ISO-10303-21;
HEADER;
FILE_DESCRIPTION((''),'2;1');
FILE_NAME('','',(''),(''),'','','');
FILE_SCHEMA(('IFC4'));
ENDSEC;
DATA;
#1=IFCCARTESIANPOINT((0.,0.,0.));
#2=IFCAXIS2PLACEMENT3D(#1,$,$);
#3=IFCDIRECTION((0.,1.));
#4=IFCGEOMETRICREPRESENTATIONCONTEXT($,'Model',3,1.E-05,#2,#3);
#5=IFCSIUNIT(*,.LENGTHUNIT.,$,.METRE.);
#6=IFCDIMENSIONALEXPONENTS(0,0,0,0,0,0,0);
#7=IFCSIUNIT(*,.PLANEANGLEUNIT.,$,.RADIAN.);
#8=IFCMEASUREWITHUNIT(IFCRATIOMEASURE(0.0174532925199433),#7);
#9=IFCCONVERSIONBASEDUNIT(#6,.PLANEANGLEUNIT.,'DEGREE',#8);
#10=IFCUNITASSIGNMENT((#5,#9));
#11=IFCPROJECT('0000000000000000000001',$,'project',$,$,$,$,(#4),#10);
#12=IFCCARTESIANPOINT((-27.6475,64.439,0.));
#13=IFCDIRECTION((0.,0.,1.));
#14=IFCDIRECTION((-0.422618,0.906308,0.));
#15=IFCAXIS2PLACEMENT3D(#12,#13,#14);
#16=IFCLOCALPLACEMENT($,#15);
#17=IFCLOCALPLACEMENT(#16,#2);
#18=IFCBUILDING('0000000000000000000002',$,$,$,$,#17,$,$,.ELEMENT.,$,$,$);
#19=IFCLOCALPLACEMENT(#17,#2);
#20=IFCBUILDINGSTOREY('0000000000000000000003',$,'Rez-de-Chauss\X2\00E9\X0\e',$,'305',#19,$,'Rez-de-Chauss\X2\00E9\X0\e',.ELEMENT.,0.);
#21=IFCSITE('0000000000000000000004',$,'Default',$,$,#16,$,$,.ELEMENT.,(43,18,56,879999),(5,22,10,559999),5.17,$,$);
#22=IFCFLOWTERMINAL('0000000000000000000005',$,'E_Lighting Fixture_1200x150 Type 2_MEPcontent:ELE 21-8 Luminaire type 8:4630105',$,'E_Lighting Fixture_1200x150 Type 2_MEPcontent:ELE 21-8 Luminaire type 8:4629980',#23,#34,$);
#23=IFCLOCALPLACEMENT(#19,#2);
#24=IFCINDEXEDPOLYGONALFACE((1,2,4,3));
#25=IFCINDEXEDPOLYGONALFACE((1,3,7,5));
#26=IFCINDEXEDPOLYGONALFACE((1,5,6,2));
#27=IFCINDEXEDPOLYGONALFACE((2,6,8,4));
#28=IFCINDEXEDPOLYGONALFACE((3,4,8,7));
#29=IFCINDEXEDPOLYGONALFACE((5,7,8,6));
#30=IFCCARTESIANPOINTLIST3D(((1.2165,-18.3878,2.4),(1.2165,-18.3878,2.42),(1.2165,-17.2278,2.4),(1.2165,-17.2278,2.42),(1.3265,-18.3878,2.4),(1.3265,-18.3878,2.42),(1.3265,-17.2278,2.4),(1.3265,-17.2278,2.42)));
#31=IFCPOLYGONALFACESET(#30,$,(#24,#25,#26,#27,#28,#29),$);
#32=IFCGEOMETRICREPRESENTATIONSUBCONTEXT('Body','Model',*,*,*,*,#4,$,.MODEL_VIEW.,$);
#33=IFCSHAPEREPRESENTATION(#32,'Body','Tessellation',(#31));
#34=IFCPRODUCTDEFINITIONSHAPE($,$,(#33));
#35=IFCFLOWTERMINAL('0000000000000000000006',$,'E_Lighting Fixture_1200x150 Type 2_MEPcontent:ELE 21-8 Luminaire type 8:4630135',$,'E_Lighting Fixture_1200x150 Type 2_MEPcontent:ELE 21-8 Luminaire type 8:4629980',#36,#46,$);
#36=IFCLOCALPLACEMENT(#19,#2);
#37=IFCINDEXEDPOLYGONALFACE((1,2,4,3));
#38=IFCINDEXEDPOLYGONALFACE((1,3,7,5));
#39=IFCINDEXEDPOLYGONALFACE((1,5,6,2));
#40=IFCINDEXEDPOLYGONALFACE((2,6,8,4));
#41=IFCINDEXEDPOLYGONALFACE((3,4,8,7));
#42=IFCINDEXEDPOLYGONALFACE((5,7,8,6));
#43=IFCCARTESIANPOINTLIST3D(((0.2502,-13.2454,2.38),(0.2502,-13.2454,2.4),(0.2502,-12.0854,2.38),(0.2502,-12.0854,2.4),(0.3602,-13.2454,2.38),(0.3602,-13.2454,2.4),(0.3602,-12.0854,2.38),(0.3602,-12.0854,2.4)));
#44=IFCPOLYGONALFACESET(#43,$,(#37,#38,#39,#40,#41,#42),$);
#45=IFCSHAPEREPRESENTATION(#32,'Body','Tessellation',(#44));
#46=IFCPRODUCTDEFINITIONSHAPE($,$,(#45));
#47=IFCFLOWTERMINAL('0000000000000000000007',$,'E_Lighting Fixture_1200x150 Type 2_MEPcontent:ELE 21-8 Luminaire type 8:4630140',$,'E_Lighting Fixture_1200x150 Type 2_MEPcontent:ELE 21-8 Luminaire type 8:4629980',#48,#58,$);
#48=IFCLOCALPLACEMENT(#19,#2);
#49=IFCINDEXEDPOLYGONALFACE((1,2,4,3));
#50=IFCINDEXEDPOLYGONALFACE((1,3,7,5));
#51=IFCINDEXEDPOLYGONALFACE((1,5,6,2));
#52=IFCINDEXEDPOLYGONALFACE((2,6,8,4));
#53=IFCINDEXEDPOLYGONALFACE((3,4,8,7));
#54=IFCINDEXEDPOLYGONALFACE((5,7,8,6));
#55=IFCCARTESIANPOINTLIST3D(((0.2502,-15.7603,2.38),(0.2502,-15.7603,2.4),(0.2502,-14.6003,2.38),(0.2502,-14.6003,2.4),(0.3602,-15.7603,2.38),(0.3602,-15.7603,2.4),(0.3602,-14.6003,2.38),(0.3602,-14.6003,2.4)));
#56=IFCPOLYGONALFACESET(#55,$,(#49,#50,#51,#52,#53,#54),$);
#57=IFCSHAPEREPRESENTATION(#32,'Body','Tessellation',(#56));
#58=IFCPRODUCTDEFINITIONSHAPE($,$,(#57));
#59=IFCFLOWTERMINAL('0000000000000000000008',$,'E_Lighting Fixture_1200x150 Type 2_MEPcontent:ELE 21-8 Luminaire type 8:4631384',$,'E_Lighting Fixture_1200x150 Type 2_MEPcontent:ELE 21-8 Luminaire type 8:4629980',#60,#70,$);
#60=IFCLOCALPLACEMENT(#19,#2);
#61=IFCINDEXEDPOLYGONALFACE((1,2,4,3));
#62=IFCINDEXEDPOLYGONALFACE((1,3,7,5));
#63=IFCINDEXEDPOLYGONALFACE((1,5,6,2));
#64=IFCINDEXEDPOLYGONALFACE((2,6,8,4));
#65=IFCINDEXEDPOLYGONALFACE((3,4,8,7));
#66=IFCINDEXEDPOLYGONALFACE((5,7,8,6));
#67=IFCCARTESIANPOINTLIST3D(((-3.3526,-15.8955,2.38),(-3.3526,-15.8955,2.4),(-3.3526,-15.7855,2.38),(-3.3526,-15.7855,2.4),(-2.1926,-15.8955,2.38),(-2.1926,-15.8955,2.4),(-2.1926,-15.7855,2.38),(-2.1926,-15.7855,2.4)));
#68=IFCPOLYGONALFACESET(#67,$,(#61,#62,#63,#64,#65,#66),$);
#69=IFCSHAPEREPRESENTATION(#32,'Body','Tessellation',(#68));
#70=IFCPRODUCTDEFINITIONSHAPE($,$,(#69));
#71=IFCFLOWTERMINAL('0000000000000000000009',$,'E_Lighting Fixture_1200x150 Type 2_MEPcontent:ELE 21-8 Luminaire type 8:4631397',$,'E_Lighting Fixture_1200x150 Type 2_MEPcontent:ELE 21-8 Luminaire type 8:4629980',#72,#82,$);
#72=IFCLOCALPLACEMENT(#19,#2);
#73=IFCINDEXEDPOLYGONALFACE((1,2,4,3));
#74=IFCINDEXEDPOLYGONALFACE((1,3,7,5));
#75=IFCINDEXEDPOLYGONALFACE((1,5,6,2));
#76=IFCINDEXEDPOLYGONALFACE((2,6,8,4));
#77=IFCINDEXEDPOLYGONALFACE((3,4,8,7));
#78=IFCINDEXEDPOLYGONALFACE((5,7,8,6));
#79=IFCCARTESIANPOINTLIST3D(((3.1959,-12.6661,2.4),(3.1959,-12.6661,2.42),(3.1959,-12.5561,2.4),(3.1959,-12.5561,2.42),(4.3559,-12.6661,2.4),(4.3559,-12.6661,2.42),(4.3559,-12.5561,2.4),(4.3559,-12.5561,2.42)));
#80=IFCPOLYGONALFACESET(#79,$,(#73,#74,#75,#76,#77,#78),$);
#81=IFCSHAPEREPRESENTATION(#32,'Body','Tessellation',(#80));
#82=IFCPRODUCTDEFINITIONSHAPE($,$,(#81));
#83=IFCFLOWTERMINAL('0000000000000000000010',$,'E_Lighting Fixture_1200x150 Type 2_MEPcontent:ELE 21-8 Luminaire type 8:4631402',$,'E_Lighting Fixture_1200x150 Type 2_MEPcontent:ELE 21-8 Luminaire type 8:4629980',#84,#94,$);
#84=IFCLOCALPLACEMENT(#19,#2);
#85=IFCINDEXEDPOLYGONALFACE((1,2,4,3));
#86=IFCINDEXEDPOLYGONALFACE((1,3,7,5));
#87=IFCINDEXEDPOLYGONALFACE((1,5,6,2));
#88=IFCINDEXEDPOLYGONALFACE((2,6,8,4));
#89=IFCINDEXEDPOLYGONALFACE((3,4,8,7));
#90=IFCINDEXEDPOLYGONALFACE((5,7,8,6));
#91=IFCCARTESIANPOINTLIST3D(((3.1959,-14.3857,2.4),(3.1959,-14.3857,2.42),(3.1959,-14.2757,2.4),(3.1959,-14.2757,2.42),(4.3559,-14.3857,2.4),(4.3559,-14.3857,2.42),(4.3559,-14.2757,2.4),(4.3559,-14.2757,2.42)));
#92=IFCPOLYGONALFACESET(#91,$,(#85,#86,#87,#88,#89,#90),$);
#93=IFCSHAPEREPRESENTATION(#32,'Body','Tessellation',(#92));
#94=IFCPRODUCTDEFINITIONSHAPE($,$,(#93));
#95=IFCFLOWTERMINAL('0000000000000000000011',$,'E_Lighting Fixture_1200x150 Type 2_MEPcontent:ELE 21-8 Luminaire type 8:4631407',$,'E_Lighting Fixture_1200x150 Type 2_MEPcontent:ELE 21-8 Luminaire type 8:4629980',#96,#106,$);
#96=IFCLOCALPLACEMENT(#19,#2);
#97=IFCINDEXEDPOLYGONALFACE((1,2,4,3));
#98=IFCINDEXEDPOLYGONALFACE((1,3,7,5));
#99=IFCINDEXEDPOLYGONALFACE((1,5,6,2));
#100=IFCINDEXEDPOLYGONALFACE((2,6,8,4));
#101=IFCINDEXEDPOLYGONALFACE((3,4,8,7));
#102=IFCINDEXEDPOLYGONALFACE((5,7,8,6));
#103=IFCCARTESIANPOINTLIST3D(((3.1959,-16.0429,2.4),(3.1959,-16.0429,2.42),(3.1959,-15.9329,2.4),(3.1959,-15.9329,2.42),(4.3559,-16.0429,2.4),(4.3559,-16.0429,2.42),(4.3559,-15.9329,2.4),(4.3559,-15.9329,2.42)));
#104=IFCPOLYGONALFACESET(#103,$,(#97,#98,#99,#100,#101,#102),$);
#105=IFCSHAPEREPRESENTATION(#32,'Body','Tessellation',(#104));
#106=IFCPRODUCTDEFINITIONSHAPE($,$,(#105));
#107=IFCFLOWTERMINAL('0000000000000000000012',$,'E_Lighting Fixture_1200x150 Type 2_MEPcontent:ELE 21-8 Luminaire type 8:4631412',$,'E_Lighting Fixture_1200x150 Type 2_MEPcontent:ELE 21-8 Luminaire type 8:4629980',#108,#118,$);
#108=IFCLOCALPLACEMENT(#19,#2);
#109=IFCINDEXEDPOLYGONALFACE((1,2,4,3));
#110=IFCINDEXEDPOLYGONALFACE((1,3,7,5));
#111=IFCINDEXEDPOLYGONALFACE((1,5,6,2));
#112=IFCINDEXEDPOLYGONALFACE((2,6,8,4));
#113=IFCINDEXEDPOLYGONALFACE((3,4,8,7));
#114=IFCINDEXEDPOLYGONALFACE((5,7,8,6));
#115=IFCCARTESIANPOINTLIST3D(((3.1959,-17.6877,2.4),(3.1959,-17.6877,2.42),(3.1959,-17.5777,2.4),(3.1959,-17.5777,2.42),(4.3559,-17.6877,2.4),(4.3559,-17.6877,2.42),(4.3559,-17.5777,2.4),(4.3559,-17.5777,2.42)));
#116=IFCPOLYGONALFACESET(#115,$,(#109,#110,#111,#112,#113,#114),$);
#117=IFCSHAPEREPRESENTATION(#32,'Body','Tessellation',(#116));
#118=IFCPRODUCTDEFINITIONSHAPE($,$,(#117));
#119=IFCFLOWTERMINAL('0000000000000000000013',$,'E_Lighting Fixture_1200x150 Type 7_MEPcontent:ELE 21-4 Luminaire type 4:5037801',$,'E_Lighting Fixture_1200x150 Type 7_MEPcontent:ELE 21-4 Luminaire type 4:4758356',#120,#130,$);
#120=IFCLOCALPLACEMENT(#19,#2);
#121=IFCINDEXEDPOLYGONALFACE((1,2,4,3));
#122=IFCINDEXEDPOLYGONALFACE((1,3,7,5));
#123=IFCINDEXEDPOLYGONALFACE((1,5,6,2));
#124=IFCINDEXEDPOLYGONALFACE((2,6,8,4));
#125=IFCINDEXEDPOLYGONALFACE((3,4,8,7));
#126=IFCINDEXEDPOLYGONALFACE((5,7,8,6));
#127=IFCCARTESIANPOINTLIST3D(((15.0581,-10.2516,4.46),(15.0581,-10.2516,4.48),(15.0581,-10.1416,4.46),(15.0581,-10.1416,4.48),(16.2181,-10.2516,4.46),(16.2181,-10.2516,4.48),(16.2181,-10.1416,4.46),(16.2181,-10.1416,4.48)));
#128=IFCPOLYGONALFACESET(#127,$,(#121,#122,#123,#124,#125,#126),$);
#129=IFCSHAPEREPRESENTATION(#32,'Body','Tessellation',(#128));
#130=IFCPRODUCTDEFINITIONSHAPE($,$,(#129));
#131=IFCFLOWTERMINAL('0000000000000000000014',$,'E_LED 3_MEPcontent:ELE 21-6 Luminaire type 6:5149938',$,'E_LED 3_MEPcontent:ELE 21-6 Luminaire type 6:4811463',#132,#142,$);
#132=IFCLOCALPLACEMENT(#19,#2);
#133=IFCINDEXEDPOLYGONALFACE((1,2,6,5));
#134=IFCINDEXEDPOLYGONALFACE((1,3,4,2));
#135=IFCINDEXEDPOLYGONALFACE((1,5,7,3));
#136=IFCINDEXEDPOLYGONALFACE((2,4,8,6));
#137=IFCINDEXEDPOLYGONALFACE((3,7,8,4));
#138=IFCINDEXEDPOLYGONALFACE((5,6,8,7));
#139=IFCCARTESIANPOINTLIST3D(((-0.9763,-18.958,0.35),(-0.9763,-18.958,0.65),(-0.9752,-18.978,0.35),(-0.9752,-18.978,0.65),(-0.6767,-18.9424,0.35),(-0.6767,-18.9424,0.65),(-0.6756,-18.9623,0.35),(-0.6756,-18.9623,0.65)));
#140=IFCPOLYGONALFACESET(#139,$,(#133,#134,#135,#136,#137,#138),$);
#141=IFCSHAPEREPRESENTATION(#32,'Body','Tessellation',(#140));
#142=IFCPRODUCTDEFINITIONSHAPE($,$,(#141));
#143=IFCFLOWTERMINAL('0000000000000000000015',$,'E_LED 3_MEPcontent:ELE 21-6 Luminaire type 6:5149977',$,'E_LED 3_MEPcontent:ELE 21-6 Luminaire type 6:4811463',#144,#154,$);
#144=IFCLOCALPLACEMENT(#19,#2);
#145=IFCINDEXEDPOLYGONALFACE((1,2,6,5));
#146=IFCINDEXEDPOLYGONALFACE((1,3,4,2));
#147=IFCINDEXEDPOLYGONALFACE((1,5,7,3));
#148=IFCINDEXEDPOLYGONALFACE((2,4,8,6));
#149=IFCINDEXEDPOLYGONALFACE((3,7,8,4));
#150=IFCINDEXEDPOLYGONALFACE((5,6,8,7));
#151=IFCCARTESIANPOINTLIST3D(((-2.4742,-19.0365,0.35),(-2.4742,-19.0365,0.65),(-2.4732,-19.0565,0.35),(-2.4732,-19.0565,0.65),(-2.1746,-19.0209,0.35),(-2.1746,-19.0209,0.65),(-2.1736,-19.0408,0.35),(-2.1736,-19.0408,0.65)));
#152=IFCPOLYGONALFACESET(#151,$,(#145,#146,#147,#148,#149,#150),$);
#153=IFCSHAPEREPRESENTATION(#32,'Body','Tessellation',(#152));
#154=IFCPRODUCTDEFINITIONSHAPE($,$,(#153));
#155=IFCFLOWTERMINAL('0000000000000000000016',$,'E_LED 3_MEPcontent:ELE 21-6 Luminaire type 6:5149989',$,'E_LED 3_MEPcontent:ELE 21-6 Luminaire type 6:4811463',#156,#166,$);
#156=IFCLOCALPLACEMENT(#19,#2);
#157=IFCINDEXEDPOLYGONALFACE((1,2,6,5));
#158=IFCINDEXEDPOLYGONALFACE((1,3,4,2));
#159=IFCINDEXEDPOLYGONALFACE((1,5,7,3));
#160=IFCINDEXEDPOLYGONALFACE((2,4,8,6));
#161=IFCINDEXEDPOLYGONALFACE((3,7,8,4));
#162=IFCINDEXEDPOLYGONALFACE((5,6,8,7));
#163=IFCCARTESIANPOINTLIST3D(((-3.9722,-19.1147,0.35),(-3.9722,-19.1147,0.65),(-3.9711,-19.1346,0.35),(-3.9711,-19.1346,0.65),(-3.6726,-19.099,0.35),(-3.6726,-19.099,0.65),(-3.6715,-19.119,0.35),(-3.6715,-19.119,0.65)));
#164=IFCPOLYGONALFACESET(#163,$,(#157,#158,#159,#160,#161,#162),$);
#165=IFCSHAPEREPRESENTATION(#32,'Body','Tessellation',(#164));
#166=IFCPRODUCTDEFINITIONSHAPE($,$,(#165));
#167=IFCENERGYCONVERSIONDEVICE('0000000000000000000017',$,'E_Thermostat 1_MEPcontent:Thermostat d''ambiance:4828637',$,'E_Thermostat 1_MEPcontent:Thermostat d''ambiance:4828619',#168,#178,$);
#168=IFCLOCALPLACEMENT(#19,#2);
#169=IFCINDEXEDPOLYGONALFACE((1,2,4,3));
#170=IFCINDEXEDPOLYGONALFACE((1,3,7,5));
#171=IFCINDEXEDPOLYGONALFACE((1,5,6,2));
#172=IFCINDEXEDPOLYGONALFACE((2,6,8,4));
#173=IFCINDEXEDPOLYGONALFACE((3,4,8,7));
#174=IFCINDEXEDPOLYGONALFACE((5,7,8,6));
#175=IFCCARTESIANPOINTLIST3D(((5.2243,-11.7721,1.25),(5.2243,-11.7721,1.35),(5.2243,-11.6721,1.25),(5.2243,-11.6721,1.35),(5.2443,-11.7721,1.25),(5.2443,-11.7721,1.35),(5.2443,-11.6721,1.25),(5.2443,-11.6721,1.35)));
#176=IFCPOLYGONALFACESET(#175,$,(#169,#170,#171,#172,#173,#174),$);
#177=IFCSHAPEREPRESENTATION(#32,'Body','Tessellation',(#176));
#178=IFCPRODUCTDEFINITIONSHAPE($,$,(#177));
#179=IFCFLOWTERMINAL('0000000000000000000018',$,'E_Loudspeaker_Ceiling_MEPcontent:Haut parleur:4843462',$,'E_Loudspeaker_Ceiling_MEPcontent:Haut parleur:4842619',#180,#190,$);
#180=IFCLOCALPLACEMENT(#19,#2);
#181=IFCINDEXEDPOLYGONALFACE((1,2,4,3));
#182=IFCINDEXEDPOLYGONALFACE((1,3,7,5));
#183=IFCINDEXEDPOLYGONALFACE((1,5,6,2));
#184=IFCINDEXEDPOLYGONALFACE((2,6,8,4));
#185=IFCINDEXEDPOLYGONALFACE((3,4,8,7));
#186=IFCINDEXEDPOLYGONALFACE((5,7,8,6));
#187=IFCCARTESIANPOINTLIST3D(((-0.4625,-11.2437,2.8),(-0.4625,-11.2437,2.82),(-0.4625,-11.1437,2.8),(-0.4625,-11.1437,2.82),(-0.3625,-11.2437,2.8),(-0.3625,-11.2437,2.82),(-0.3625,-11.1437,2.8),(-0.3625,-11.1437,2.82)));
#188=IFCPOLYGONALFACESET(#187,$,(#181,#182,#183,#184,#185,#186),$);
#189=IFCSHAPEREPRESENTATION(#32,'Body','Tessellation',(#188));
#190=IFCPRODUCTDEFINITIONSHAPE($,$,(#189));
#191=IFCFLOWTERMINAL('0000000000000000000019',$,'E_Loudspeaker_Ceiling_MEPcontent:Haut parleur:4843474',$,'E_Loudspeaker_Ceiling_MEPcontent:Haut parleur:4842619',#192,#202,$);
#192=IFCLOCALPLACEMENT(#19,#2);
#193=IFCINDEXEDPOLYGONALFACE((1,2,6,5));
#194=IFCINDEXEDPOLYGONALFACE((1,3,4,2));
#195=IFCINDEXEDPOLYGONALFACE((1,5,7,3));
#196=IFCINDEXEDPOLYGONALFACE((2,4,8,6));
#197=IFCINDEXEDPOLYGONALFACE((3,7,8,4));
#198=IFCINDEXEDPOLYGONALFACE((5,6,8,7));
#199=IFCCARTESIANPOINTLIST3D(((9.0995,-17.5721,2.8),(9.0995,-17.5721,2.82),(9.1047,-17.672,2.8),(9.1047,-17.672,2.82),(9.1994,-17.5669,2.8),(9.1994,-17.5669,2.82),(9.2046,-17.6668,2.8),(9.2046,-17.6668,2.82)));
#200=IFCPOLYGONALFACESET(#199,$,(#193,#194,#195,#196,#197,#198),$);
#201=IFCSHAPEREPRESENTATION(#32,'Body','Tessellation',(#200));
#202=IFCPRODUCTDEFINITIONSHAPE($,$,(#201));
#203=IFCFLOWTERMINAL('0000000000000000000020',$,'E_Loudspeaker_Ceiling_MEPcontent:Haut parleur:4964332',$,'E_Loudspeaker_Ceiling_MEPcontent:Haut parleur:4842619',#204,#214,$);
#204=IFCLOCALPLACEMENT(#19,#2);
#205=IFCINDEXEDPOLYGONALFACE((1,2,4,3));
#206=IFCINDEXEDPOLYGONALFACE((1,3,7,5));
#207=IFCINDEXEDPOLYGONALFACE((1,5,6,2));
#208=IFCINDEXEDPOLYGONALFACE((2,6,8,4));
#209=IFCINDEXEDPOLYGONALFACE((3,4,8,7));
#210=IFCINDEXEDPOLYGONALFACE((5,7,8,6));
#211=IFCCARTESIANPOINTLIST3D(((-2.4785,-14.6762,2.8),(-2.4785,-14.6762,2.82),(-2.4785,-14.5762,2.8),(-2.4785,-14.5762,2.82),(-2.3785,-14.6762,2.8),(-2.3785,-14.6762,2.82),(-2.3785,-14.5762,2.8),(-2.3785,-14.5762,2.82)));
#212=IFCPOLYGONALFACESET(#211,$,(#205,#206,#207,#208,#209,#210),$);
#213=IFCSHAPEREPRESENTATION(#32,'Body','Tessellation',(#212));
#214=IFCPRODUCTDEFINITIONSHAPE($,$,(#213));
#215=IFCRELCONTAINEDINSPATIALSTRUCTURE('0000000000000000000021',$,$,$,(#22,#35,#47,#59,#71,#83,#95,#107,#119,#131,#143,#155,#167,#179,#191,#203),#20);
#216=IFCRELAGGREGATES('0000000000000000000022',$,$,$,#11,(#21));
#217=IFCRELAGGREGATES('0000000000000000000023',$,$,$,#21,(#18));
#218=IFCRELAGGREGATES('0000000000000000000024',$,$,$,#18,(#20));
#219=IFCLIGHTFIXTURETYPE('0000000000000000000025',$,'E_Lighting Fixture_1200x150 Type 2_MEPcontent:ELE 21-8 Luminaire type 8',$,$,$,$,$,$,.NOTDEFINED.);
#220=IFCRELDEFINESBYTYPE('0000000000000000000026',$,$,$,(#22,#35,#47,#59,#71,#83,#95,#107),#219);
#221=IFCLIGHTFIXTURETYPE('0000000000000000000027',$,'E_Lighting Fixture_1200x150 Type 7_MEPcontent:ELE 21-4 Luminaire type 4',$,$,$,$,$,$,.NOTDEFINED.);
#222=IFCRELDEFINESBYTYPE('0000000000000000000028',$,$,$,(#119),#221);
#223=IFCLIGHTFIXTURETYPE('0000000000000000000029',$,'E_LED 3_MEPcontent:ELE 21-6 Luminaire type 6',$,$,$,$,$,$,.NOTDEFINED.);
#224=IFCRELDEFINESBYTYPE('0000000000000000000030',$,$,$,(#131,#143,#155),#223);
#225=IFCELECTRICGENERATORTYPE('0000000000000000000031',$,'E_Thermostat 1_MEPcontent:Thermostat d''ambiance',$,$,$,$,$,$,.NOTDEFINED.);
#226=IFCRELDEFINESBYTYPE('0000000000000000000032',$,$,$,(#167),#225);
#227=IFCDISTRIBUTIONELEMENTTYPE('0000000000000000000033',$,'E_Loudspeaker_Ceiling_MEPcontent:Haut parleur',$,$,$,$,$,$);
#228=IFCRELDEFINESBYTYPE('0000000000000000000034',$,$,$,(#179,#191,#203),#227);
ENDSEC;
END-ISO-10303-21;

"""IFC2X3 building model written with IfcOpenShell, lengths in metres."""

from ifc_helpers import new_model, entity, si_unit, converted_unit, direction, frame, frame_2d, origin, origin_2d_with_axis, place, context, subcontext, project, spatial, rectangle, extrude, source, transform, mapped, type_object, type_shapes, element, save


model = new_model("IFC2X3")

# Units and contexts
model_context = context("Model", 3, precision=1e-05, world=origin(), true_north=direction((0.0, 1.0)))
body_context = subcontext(model_context, "Body", "Model", "MODEL_VIEW")
ifc_project = project(units=[si_unit("LENGTHUNIT", "METRE"), converted_unit("PLANEANGLEUNIT", "DEGREE", entity("IfcRatioMeasure", 0.0174532925199433), si_unit("PLANEANGLEUNIT", "RADIAN"), dimensions=[0, 0, 0, 0, 0, 0, 0])], contexts=[model_context])

# Site, building, storey
site_placement = place(None, frame((-27.6475, 64.439, 0.0), z_axis=(0.0, 0.0, 1.0), x_axis=(-0.422618, 0.906308, 0.0)))
site = spatial("IfcSite", under=ifc_project, at=site_placement, Name="Default", CompositionType="ELEMENT", RefLatitude=(43, 18, 56, 879999), RefLongitude=(5, 22, 10, 559999), RefElevation=5.17)
building_placement = place(site_placement, origin())
building = spatial("IfcBuilding", under=site, at=building_placement, CompositionType="ELEMENT")
storey_placement = place(building_placement, origin())
storey = spatial("IfcBuildingStorey", under=building, at=storey_placement, Name="Rez-de-Chaussée", ObjectType="305", LongName="Rez-de-Chaussée", CompositionType="ELEMENT", Elevation=0.0)

# Flow terminals
light_fixture_type_1 = type_object("IfcLightFixtureType", Name="E_Lighting Fixture_1200x150 Type 2_MEPcontent:ELE 21-8 Luminaire type 8", PredefinedType="NOTDEFINED")
shared_shape_1 = source(origin(), body_context, "Body", "SweptSolid", [
    extrude(rectangle(XDim=0.11, YDim=1.16, at=origin_2d_with_axis()), frame((0.0, 0.0, 0.0), z_axis=(0.0, 0.0, 1.0), x_axis=(0.0, -1.0, 0.0)), (0.0, 0.0, 1.0), 0.02),
])
type_shapes(light_fixture_type_1, [shared_shape_1])
for number, where, z_axis, x_axis, name in (
    (1, (1.2715, -17.8078, 2.4), (0.0, 0.0, 1.0), (0.0, -1.0, 0.0), "E_Lighting Fixture_1200x150 Type 2_MEPcontent:ELE 21-8 Luminaire type 8:4630105"),
    (2, (0.3052, -12.6654, 2.38), (0.0, 0.0, 1.0), (0.0, -1.0, 0.0), "E_Lighting Fixture_1200x150 Type 2_MEPcontent:ELE 21-8 Luminaire type 8:4630135"),
    (3, (0.3052, -15.1803, 2.38), (0.0, 0.0, 1.0), (0.0, -1.0, 0.0), "E_Lighting Fixture_1200x150 Type 2_MEPcontent:ELE 21-8 Luminaire type 8:4630140"),
):
    element("IfcFlowTerminal", number, at=place(storey_placement, frame(where, z_axis=z_axis, x_axis=x_axis)), inside=storey, type_object=light_fixture_type_1, Name=name, ObjectType="E_Lighting Fixture_1200x150 Type 2_MEPcontent:ELE 21-8 Luminaire type 8:4629980", context=body_context, shape_type="MappedRepresentation", body=[
        mapped(shared_shape_1, transform((0.0, 0.0, 0.0), scale=1.0)),
    ])
for number, where, name in (
    (4, (-2.7726, -15.8405, 2.38), "E_Lighting Fixture_1200x150 Type 2_MEPcontent:ELE 21-8 Luminaire type 8:4631384"),
    (5, (3.7759, -12.6111, 2.4), "E_Lighting Fixture_1200x150 Type 2_MEPcontent:ELE 21-8 Luminaire type 8:4631397"),
    (6, (3.7759, -14.3307, 2.4), "E_Lighting Fixture_1200x150 Type 2_MEPcontent:ELE 21-8 Luminaire type 8:4631402"),
    (7, (3.7759, -15.9879, 2.4), "E_Lighting Fixture_1200x150 Type 2_MEPcontent:ELE 21-8 Luminaire type 8:4631407"),
    (8, (3.7759, -17.6327, 2.4), "E_Lighting Fixture_1200x150 Type 2_MEPcontent:ELE 21-8 Luminaire type 8:4631412"),
):
    element("IfcFlowTerminal", number, at=place(storey_placement, frame(where)), inside=storey, type_object=light_fixture_type_1, Name=name, ObjectType="E_Lighting Fixture_1200x150 Type 2_MEPcontent:ELE 21-8 Luminaire type 8:4629980", context=body_context, shape_type="MappedRepresentation", body=[
        mapped(shared_shape_1, transform((0.0, 0.0, 0.0), scale=1.0)),
    ])
light_fixture_type_2 = type_object("IfcLightFixtureType", Name="E_Lighting Fixture_1200x150 Type 7_MEPcontent:ELE 21-4 Luminaire type 4", PredefinedType="NOTDEFINED")
shared_shape_2 = source(origin(), body_context, "Body", "SweptSolid", [
    extrude(rectangle(XDim=0.11, YDim=1.16, at=origin_2d_with_axis()), frame((0.0, 0.0, 0.0), z_axis=(0.0, 0.0, 1.0), x_axis=(0.0, -1.0, 0.0)), (0.0, 0.0, 1.0), 0.02),
])
type_shapes(light_fixture_type_2, [shared_shape_2])
flow_terminal_1_placement = place(storey_placement, frame((15.6381, -10.1966, 4.46)))
element("IfcFlowTerminal", 9, at=flow_terminal_1_placement, inside=storey, type_object=light_fixture_type_2, Name="E_Lighting Fixture_1200x150 Type 7_MEPcontent:ELE 21-4 Luminaire type 4:5037801", ObjectType="E_Lighting Fixture_1200x150 Type 7_MEPcontent:ELE 21-4 Luminaire type 4:4758356", context=body_context, shape_type="MappedRepresentation", body=[
    mapped(shared_shape_2, transform((0.0, 0.0, 0.0), scale=1.0)),
])
light_fixture_type_3 = type_object("IfcLightFixtureType", Name="E_LED 3_MEPcontent:ELE 21-6 Luminaire type 6", PredefinedType="NOTDEFINED")
shared_shape_3 = source(origin(), body_context, "Body", "SweptSolid", [
    extrude(rectangle(XDim=0.02, YDim=0.3, at=origin_2d_with_axis()), frame((-0.01, 0.0, -0.15)), (0.0, 0.0, 1.0), 0.3),
])
type_shapes(light_fixture_type_3, [shared_shape_3])
for number, where, z_axis, x_axis, name in (
    (10, (-0.8254, -18.9701, 0.5), (0.0, 0.0, 1.0), (0.05212, -0.998641, 0.0), "E_LED 3_MEPcontent:ELE 21-6 Luminaire type 6:5149938"),
    (11, (-2.3234, -19.0487, 0.5), (0.0, 0.0, 1.0), (0.05212, -0.998641, 0.0), "E_LED 3_MEPcontent:ELE 21-6 Luminaire type 6:5149977"),
    (12, (-3.8213, -19.1268, 0.5), (0.0, 0.0, 1.0), (0.05212, -0.998641, 0.0), "E_LED 3_MEPcontent:ELE 21-6 Luminaire type 6:5149989"),
):
    element("IfcFlowTerminal", number, at=place(storey_placement, frame(where, z_axis=z_axis, x_axis=x_axis)), inside=storey, type_object=light_fixture_type_3, Name=name, ObjectType="E_LED 3_MEPcontent:ELE 21-6 Luminaire type 6:4811463", context=body_context, shape_type="MappedRepresentation", body=[
        mapped(shared_shape_3, transform((0.0, 0.0, 0.0), scale=1.0)),
    ])

# Energy conversion device
electric_generator_type_1 = type_object("IfcElectricGeneratorType", Name="E_Thermostat 1_MEPcontent:Thermostat d'ambiance", PredefinedType="NOTDEFINED")
shared_shape_4 = source(origin(), body_context, "Body", "SweptSolid", [
    extrude(rectangle(XDim=0.02, YDim=0.1, at=frame_2d((0.0, 0.0), x_axis=(1.0, 0.0))), frame((0.0, 0.01, -0.05), z_axis=(0.0, 0.0, 1.0), x_axis=(0.0, -1.0, 0.0)), (0.0, 0.0, 1.0), 0.1),
])
type_shapes(electric_generator_type_1, [shared_shape_4])
energy_conversion_device_1_placement = place(storey_placement, frame((5.2243, -11.7221, 1.3), z_axis=(0.0, 0.0, 1.0), x_axis=(0.0, -1.0, 0.0)))
element("IfcEnergyConversionDevice", 13, at=energy_conversion_device_1_placement, inside=storey, type_object=electric_generator_type_1, Name="E_Thermostat 1_MEPcontent:Thermostat d'ambiance:4828637", ObjectType="E_Thermostat 1_MEPcontent:Thermostat d'ambiance:4828619", context=body_context, shape_type="MappedRepresentation", body=[
    mapped(shared_shape_4, transform((0.0, 0.0, 0.0), scale=1.0)),
])

# Flow terminals
distribution_element_type_1 = type_object("IfcDistributionElementType", Name="E_Loudspeaker_Ceiling_MEPcontent:Haut parleur")
shared_shape_5 = source(origin(), body_context, "Body", "SweptSolid", [
    extrude(rectangle(XDim=0.1, YDim=0.1, at=origin_2d_with_axis()), frame((0.0, 0.0, 0.0), z_axis=(0.0, 0.0, 1.0), x_axis=(0.0, -1.0, 0.0)), (0.0, 0.0, 1.0), 0.02),
])
type_shapes(distribution_element_type_1, [shared_shape_5])
flow_terminal_2_placement = place(storey_placement, frame((-0.4125, -11.1937, 2.8)))
element("IfcFlowTerminal", 14, at=flow_terminal_2_placement, inside=storey, type_object=distribution_element_type_1, Name="E_Loudspeaker_Ceiling_MEPcontent:Haut parleur:4843462", ObjectType="E_Loudspeaker_Ceiling_MEPcontent:Haut parleur:4842619", context=body_context, shape_type="MappedRepresentation", body=[
    mapped(shared_shape_5, transform((0.0, 0.0, 0.0), scale=1.0)),
])
for number, where, z_axis, x_axis, name in (
    (15, (9.1521, -17.6194, 2.8), (0.0, 0.0, 1.0), (0.998656, 0.051826, 0.0), "E_Loudspeaker_Ceiling_MEPcontent:Haut parleur:4843474"),
    (16, (-2.4285, -14.6262, 2.8), (0.0, 0.0, 1.0), (-1.0, 0.0, 0.0), "E_Loudspeaker_Ceiling_MEPcontent:Haut parleur:4964332"),
):
    element("IfcFlowTerminal", number, at=place(storey_placement, frame(where, z_axis=z_axis, x_axis=x_axis)), inside=storey, type_object=distribution_element_type_1, Name=name, ObjectType="E_Loudspeaker_Ceiling_MEPcontent:Haut parleur:4842619", context=body_context, shape_type="MappedRepresentation", body=[
        mapped(shared_shape_5, transform((0.0, 0.0, 0.0), scale=1.0)),
    ])

save(model, "model.ifc")
